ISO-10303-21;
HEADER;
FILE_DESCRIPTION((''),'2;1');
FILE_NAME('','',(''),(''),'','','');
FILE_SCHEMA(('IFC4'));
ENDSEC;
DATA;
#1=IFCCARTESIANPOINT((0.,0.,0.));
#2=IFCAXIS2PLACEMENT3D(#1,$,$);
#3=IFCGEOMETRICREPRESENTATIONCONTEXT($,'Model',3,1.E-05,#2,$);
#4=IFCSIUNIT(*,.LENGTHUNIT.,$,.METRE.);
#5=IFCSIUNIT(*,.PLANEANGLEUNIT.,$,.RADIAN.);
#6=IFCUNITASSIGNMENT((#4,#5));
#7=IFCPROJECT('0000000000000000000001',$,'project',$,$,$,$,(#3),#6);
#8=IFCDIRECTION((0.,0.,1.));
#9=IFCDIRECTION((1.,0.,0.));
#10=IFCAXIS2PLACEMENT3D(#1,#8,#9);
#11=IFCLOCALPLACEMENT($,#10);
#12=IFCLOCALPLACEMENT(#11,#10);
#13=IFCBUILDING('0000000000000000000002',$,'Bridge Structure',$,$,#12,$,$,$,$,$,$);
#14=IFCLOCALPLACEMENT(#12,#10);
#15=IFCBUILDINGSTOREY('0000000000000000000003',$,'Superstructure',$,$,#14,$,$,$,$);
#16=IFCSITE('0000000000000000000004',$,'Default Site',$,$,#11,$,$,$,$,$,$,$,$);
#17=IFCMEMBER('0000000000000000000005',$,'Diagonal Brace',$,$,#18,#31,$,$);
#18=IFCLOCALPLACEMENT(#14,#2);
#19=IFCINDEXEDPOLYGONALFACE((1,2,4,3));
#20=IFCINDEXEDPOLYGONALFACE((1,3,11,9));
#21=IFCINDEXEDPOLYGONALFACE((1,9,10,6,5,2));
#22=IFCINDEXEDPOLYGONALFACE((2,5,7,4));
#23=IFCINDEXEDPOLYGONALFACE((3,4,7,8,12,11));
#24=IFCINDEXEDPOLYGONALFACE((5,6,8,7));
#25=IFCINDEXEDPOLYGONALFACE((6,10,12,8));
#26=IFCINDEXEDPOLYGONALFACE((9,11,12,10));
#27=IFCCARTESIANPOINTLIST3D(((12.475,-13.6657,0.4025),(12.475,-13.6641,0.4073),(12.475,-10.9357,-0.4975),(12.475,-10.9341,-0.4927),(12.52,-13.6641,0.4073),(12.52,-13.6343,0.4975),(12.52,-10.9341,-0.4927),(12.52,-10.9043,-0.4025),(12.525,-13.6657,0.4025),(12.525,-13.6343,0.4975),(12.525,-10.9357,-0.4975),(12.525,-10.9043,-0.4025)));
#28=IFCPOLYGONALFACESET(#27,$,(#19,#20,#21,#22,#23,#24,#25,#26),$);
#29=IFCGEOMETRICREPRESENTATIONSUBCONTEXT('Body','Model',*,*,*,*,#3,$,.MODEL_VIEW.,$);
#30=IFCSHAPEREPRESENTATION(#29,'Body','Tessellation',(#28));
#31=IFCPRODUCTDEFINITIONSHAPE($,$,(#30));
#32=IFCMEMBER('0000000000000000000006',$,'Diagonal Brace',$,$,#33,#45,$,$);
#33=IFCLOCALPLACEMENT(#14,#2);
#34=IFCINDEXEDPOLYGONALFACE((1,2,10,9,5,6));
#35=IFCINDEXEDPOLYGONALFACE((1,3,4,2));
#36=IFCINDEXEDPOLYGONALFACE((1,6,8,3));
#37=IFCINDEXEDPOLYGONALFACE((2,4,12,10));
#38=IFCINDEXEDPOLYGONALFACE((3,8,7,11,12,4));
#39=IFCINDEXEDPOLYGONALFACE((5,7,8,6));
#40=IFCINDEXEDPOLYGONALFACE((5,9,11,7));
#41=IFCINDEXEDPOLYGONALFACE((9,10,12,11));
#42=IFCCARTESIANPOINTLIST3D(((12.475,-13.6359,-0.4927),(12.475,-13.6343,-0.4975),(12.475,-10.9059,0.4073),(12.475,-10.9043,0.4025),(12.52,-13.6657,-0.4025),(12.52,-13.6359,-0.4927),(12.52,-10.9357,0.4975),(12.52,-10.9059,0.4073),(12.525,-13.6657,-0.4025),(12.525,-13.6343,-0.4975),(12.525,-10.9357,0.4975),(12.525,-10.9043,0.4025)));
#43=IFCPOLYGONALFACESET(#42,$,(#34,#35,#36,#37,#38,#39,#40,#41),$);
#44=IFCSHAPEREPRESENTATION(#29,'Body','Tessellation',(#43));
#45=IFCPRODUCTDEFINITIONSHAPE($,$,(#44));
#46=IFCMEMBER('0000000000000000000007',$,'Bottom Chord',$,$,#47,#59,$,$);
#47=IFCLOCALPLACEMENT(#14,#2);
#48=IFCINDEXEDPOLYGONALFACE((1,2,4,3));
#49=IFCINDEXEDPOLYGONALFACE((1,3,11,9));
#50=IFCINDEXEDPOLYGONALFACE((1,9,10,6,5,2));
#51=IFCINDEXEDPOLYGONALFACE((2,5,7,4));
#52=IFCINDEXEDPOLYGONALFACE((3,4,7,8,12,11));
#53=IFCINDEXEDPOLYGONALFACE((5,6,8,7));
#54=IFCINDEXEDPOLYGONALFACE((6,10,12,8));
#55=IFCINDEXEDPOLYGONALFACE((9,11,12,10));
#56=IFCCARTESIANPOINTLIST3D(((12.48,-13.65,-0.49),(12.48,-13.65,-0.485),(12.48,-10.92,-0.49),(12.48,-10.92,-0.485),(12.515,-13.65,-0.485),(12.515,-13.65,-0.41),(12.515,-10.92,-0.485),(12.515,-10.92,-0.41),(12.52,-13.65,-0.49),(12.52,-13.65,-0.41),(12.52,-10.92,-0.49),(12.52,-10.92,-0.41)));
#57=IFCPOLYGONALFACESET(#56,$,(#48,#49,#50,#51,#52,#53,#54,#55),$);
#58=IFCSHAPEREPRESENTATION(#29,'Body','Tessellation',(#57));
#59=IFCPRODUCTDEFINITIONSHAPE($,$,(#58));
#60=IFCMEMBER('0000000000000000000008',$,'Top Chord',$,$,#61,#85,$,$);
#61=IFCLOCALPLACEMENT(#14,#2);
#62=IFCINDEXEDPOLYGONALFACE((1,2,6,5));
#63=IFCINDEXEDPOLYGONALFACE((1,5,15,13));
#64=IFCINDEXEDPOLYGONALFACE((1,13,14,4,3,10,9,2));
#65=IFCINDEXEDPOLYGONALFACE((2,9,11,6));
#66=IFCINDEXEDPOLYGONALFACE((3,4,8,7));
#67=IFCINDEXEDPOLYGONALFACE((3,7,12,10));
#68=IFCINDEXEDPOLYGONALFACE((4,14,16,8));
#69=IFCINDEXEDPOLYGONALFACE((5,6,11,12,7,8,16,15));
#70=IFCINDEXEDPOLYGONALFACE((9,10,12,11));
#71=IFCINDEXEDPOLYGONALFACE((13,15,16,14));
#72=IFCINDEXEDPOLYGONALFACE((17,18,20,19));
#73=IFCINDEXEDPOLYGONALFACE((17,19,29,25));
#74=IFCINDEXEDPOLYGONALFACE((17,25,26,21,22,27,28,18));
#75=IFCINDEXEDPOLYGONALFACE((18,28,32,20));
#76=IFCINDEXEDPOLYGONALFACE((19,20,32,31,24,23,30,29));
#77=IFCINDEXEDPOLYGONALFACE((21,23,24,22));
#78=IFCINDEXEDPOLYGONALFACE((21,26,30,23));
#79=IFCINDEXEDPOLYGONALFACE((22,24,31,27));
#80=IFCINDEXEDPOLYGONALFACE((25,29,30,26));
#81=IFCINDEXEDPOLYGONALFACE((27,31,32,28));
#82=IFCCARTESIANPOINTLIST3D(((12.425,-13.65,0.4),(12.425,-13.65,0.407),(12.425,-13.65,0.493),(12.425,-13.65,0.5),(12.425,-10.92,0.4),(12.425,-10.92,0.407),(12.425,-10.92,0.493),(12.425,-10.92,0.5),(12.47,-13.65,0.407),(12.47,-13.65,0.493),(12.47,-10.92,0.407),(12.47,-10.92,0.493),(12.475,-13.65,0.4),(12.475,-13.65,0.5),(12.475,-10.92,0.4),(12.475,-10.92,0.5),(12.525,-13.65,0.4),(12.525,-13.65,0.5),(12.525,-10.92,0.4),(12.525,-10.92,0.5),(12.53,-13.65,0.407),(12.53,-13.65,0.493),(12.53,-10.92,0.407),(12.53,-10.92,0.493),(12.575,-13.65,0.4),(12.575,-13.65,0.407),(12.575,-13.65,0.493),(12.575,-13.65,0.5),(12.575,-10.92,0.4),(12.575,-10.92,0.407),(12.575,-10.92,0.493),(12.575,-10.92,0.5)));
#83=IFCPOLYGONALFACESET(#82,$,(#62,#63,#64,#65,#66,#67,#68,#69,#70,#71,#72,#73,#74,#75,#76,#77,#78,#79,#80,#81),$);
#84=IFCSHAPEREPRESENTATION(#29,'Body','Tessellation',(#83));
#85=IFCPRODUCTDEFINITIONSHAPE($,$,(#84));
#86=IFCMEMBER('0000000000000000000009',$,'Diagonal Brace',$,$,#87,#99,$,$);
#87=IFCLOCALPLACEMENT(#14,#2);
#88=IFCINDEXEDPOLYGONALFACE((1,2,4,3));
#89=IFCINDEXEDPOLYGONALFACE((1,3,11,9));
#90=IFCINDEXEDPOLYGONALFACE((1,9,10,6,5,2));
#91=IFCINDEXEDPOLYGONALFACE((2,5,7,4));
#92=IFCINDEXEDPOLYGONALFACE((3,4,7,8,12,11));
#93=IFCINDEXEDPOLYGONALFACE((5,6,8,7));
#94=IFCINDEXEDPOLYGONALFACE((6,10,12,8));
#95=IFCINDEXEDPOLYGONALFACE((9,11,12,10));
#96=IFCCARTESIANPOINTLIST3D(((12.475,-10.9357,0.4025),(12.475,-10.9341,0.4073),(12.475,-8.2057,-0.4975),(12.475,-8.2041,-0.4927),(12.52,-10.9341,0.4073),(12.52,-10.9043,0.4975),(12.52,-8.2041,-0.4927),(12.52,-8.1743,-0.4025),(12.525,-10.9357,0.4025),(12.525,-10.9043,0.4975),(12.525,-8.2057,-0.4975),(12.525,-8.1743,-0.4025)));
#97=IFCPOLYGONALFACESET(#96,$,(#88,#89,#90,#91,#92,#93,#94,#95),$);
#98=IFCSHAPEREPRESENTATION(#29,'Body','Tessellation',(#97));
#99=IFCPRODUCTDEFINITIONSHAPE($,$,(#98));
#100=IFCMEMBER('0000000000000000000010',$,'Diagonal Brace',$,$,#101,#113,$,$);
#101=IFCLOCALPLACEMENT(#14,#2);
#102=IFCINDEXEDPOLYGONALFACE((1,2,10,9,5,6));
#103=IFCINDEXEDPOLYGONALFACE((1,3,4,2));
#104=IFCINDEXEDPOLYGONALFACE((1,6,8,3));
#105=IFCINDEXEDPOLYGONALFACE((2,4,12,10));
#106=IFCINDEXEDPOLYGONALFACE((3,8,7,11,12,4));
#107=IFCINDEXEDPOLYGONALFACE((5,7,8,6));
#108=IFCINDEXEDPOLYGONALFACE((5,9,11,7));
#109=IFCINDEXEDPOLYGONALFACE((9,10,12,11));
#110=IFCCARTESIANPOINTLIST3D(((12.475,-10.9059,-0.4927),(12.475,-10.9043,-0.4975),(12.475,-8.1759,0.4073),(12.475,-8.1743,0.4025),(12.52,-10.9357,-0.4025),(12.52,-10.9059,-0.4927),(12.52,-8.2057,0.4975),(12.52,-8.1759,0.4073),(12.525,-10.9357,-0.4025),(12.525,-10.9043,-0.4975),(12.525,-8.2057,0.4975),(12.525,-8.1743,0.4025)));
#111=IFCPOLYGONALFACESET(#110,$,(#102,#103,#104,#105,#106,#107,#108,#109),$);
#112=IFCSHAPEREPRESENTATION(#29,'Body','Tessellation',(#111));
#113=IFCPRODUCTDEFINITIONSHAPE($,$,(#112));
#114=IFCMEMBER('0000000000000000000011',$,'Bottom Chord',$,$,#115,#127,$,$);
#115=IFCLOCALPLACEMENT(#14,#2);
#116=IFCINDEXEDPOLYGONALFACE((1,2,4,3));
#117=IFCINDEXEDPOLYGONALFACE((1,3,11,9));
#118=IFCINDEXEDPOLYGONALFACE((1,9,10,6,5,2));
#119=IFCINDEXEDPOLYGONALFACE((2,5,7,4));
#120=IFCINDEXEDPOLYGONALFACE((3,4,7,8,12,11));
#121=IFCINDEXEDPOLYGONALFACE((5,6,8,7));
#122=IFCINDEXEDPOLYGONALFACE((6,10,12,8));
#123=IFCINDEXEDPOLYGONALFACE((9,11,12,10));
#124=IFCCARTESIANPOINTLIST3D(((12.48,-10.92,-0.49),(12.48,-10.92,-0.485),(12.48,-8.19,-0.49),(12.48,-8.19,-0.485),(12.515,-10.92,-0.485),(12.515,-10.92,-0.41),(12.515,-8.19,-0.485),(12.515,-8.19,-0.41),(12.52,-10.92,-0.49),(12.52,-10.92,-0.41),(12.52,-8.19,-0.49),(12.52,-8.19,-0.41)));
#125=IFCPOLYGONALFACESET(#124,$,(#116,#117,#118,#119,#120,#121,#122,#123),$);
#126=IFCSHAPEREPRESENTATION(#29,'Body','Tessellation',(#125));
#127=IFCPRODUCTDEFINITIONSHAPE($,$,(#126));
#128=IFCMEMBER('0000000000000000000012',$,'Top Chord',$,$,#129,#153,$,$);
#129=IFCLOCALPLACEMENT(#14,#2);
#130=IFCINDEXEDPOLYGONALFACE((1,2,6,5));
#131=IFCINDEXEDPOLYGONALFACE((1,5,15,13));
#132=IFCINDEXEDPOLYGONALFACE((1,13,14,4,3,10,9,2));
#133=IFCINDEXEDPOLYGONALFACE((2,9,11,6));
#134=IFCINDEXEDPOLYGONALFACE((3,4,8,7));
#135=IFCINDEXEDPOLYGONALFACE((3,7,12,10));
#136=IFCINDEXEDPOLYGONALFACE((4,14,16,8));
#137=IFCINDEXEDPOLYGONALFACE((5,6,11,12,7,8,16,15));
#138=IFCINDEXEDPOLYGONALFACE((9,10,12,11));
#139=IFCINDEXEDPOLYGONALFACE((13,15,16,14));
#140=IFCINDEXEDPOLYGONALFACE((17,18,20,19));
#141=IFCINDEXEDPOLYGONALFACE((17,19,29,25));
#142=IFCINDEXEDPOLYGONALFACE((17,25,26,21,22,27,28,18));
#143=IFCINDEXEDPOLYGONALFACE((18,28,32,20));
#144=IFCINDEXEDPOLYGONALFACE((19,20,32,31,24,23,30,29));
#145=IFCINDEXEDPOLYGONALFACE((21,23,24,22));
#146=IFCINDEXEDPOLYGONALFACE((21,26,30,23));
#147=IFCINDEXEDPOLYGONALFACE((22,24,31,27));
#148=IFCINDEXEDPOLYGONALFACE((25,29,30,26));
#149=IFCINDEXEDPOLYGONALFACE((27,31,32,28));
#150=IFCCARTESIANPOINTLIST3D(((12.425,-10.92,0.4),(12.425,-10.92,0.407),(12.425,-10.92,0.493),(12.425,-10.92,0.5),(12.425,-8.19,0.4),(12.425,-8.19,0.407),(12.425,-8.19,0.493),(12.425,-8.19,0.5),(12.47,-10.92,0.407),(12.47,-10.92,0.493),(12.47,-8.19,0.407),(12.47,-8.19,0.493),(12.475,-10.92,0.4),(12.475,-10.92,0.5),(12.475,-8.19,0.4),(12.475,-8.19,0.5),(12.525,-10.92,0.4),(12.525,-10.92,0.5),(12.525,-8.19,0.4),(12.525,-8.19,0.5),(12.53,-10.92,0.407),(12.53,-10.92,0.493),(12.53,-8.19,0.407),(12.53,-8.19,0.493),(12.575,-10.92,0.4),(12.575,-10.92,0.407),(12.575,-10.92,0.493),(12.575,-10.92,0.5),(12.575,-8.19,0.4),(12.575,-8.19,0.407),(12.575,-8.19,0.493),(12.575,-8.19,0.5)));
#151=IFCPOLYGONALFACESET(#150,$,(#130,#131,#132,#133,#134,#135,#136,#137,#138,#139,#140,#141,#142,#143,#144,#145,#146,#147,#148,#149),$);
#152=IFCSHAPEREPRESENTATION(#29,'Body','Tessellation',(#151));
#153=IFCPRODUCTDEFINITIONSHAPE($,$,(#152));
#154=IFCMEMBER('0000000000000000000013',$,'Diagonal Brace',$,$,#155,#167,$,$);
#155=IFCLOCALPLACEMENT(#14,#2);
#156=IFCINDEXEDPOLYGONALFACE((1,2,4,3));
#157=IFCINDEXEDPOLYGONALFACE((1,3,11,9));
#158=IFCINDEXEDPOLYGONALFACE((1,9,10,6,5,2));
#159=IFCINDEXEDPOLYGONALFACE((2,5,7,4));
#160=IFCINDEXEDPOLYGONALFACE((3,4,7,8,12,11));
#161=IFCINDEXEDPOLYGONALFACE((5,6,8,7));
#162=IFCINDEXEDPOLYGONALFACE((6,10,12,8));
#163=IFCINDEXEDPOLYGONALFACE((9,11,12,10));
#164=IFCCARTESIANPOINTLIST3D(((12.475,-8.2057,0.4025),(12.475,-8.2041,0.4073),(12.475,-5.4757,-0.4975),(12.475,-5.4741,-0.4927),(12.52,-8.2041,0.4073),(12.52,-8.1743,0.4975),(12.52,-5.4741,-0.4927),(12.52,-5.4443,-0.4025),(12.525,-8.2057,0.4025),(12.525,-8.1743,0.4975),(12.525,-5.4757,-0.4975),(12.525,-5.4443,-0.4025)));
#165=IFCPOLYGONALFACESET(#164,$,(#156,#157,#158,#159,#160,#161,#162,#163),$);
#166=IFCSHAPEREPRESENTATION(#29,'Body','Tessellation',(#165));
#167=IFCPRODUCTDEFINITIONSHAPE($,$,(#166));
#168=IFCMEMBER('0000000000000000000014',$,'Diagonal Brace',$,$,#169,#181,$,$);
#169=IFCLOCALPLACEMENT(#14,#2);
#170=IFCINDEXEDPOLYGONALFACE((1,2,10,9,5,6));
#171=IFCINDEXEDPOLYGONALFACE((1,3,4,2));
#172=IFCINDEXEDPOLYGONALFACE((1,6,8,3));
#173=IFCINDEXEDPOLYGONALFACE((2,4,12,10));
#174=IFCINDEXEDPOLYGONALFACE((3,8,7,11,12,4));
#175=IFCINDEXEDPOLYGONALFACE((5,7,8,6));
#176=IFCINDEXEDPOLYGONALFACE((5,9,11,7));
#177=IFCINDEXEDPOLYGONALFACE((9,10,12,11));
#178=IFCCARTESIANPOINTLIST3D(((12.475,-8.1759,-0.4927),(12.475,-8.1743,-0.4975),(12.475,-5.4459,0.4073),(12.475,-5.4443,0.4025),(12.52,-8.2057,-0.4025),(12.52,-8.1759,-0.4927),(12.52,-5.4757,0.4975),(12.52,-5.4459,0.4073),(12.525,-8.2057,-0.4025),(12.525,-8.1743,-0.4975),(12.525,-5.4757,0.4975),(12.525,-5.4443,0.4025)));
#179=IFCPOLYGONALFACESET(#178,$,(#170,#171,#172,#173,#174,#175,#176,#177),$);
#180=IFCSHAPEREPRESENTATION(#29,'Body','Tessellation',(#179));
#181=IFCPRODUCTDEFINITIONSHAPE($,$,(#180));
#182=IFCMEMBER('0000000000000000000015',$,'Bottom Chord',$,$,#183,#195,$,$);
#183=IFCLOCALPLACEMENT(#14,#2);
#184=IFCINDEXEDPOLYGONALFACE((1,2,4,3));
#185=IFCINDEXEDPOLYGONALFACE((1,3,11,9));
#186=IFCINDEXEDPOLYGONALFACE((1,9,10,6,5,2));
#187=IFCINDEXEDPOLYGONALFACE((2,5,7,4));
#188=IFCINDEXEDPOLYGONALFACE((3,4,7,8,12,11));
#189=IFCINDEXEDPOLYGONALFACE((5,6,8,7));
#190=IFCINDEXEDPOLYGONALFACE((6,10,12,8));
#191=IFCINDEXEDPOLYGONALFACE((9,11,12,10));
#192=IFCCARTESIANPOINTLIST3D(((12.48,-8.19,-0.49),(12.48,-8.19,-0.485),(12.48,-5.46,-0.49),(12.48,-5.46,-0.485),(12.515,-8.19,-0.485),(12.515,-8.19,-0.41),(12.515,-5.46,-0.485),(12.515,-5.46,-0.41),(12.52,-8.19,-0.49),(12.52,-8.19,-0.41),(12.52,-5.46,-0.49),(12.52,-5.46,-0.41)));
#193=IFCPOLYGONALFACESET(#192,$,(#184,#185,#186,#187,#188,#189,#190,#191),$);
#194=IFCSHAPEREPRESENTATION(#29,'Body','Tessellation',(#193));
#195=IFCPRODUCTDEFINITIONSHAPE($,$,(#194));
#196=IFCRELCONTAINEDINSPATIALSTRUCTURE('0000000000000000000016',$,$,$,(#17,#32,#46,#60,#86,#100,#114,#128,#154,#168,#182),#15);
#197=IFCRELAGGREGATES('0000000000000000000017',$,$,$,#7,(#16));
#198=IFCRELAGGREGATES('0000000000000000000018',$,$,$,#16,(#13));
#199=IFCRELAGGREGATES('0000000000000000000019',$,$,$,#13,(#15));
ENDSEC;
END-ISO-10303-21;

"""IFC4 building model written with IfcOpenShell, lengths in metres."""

from ifc_helpers import new_model, si_unit, frame, origin, origin_with_axes, origin_2d_with_axis, place, context, subcontext, project, spatial, polyline, l_section, outline, composite_profile, extrude, element, save


model = new_model("IFC4")

# Units and contexts
model_context = context("Model", 3, precision=1e-05, world=origin())
body_context = subcontext(model_context, "Body", "Model", "MODEL_VIEW")
ifc_project = project(units=[si_unit("LENGTHUNIT", "METRE"), si_unit("PLANEANGLEUNIT", "RADIAN")], contexts=[model_context])

# Site, building, storey
site_placement = place(None, origin_with_axes())
site = spatial("IfcSite", under=ifc_project, at=site_placement, Name="Default Site")
building_placement = place(site_placement, origin_with_axes())
building = spatial("IfcBuilding", under=site, at=building_placement, Name="Bridge Structure")
storey_placement = place(building_placement, origin_with_axes())
storey = spatial("IfcBuildingStorey", under=building, at=storey_placement, Name="Superstructure")

# Members
for number, where, z_axis, x_axis, name in (
    (1, (12.5, -13.65, 0.45), (0.0, 0.949722, -0.313095), (-1.0, 0.0, 0.0), "Diagonal Brace"),
    (2, (12.5, -13.65, -0.45), (0.0, 0.949722, 0.313095), (-1.0, 0.0, 0.0), "Diagonal Brace"),
):
    element("IfcMember", number, at=place(storey_placement, frame(where, z_axis=z_axis, x_axis=x_axis)), inside=storey, Name=name, context=body_context, shape_type="SweptSolid", body=[
        extrude(l_section(Depth=0.1, Width=0.05, Thickness=0.005, at=origin_2d_with_axis()), origin_with_axes(), (0.0, 0.0, 1.0), 2.8745),
    ])
member_1_placement = place(storey_placement, frame((12.5, -13.65, -0.45), z_axis=(0.0, 1.0, 0.0), x_axis=(-1.0, 0.0, 0.0)))
element("IfcMember", 3, at=member_1_placement, inside=storey, Name="Bottom Chord", context=body_context, shape_type="SweptSolid", body=[
    extrude(l_section(Depth=0.08, Width=0.04, Thickness=0.005, at=origin_2d_with_axis()), origin_with_axes(), (0.0, 0.0, 1.0), 2.73),
])
member_2_placement = place(storey_placement, frame((12.5, -13.65, 0.45), z_axis=(0.0, 1.0, 0.0), x_axis=(-1.0, 0.0, 0.0)))
element("IfcMember", 4, at=member_2_placement, inside=storey, Name="Top Chord", context=body_context, shape_type="SweptSolid", body=[
    extrude(composite_profile([outline(polyline([(-0.025, -0.05), (-0.025, 0.05), (-0.075, 0.05), (-0.075, 0.043), (-0.03, 0.043), (-0.03, -0.043), (-0.075, -0.043), (-0.075, -0.05), (-0.025, -0.05)])), outline(polyline([(0.025, -0.05), (0.075, -0.05), (0.075, -0.043), (0.03, -0.043), (0.03, 0.043), (0.075, 0.043), (0.075, 0.05), (0.025, 0.05), (0.025, -0.05)]))]), origin_with_axes(), (0.0, 0.0, 1.0), 2.73),
])
for number, where, z_axis, x_axis, name in (
    (5, (12.5, -10.92, 0.45), (0.0, 0.949722, -0.313095), (-1.0, 0.0, 0.0), "Diagonal Brace"),
    (6, (12.5, -10.92, -0.45), (0.0, 0.949722, 0.313095), (-1.0, 0.0, 0.0), "Diagonal Brace"),
):
    element("IfcMember", number, at=place(storey_placement, frame(where, z_axis=z_axis, x_axis=x_axis)), inside=storey, Name=name, context=body_context, shape_type="SweptSolid", body=[
        extrude(l_section(Depth=0.1, Width=0.05, Thickness=0.005, at=origin_2d_with_axis()), origin_with_axes(), (0.0, 0.0, 1.0), 2.8745),
    ])
member_3_placement = place(storey_placement, frame((12.5, -10.92, -0.45), z_axis=(0.0, 1.0, 0.0), x_axis=(-1.0, 0.0, 0.0)))
element("IfcMember", 7, at=member_3_placement, inside=storey, Name="Bottom Chord", context=body_context, shape_type="SweptSolid", body=[
    extrude(l_section(Depth=0.08, Width=0.04, Thickness=0.005, at=origin_2d_with_axis()), origin_with_axes(), (0.0, 0.0, 1.0), 2.73),
])
member_4_placement = place(storey_placement, frame((12.5, -10.92, 0.45), z_axis=(0.0, 1.0, 0.0), x_axis=(-1.0, 0.0, 0.0)))
element("IfcMember", 8, at=member_4_placement, inside=storey, Name="Top Chord", context=body_context, shape_type="SweptSolid", body=[
    extrude(composite_profile([outline(polyline([(-0.025, -0.05), (-0.025, 0.05), (-0.075, 0.05), (-0.075, 0.043), (-0.03, 0.043), (-0.03, -0.043), (-0.075, -0.043), (-0.075, -0.05), (-0.025, -0.05)])), outline(polyline([(0.025, -0.05), (0.075, -0.05), (0.075, -0.043), (0.03, -0.043), (0.03, 0.043), (0.075, 0.043), (0.075, 0.05), (0.025, 0.05), (0.025, -0.05)]))]), origin_with_axes(), (0.0, 0.0, 1.0), 2.73),
])
for number, where, z_axis, x_axis, name in (
    (9, (12.5, -8.19, 0.45), (0.0, 0.949722, -0.313095), (-1.0, 0.0, 0.0), "Diagonal Brace"),
    (10, (12.5, -8.19, -0.45), (0.0, 0.949722, 0.313095), (-1.0, 0.0, 0.0), "Diagonal Brace"),
):
    element("IfcMember", number, at=place(storey_placement, frame(where, z_axis=z_axis, x_axis=x_axis)), inside=storey, Name=name, context=body_context, shape_type="SweptSolid", body=[
        extrude(l_section(Depth=0.1, Width=0.05, Thickness=0.005, at=origin_2d_with_axis()), origin_with_axes(), (0.0, 0.0, 1.0), 2.8745),
    ])
member_5_placement = place(storey_placement, frame((12.5, -8.19, -0.45), z_axis=(0.0, 1.0, 0.0), x_axis=(-1.0, 0.0, 0.0)))
element("IfcMember", 11, at=member_5_placement, inside=storey, Name="Bottom Chord", context=body_context, shape_type="SweptSolid", body=[
    extrude(l_section(Depth=0.08, Width=0.04, Thickness=0.005, at=origin_2d_with_axis()), origin_with_axes(), (0.0, 0.0, 1.0), 2.73),
])

save(model, "model.ifc")
